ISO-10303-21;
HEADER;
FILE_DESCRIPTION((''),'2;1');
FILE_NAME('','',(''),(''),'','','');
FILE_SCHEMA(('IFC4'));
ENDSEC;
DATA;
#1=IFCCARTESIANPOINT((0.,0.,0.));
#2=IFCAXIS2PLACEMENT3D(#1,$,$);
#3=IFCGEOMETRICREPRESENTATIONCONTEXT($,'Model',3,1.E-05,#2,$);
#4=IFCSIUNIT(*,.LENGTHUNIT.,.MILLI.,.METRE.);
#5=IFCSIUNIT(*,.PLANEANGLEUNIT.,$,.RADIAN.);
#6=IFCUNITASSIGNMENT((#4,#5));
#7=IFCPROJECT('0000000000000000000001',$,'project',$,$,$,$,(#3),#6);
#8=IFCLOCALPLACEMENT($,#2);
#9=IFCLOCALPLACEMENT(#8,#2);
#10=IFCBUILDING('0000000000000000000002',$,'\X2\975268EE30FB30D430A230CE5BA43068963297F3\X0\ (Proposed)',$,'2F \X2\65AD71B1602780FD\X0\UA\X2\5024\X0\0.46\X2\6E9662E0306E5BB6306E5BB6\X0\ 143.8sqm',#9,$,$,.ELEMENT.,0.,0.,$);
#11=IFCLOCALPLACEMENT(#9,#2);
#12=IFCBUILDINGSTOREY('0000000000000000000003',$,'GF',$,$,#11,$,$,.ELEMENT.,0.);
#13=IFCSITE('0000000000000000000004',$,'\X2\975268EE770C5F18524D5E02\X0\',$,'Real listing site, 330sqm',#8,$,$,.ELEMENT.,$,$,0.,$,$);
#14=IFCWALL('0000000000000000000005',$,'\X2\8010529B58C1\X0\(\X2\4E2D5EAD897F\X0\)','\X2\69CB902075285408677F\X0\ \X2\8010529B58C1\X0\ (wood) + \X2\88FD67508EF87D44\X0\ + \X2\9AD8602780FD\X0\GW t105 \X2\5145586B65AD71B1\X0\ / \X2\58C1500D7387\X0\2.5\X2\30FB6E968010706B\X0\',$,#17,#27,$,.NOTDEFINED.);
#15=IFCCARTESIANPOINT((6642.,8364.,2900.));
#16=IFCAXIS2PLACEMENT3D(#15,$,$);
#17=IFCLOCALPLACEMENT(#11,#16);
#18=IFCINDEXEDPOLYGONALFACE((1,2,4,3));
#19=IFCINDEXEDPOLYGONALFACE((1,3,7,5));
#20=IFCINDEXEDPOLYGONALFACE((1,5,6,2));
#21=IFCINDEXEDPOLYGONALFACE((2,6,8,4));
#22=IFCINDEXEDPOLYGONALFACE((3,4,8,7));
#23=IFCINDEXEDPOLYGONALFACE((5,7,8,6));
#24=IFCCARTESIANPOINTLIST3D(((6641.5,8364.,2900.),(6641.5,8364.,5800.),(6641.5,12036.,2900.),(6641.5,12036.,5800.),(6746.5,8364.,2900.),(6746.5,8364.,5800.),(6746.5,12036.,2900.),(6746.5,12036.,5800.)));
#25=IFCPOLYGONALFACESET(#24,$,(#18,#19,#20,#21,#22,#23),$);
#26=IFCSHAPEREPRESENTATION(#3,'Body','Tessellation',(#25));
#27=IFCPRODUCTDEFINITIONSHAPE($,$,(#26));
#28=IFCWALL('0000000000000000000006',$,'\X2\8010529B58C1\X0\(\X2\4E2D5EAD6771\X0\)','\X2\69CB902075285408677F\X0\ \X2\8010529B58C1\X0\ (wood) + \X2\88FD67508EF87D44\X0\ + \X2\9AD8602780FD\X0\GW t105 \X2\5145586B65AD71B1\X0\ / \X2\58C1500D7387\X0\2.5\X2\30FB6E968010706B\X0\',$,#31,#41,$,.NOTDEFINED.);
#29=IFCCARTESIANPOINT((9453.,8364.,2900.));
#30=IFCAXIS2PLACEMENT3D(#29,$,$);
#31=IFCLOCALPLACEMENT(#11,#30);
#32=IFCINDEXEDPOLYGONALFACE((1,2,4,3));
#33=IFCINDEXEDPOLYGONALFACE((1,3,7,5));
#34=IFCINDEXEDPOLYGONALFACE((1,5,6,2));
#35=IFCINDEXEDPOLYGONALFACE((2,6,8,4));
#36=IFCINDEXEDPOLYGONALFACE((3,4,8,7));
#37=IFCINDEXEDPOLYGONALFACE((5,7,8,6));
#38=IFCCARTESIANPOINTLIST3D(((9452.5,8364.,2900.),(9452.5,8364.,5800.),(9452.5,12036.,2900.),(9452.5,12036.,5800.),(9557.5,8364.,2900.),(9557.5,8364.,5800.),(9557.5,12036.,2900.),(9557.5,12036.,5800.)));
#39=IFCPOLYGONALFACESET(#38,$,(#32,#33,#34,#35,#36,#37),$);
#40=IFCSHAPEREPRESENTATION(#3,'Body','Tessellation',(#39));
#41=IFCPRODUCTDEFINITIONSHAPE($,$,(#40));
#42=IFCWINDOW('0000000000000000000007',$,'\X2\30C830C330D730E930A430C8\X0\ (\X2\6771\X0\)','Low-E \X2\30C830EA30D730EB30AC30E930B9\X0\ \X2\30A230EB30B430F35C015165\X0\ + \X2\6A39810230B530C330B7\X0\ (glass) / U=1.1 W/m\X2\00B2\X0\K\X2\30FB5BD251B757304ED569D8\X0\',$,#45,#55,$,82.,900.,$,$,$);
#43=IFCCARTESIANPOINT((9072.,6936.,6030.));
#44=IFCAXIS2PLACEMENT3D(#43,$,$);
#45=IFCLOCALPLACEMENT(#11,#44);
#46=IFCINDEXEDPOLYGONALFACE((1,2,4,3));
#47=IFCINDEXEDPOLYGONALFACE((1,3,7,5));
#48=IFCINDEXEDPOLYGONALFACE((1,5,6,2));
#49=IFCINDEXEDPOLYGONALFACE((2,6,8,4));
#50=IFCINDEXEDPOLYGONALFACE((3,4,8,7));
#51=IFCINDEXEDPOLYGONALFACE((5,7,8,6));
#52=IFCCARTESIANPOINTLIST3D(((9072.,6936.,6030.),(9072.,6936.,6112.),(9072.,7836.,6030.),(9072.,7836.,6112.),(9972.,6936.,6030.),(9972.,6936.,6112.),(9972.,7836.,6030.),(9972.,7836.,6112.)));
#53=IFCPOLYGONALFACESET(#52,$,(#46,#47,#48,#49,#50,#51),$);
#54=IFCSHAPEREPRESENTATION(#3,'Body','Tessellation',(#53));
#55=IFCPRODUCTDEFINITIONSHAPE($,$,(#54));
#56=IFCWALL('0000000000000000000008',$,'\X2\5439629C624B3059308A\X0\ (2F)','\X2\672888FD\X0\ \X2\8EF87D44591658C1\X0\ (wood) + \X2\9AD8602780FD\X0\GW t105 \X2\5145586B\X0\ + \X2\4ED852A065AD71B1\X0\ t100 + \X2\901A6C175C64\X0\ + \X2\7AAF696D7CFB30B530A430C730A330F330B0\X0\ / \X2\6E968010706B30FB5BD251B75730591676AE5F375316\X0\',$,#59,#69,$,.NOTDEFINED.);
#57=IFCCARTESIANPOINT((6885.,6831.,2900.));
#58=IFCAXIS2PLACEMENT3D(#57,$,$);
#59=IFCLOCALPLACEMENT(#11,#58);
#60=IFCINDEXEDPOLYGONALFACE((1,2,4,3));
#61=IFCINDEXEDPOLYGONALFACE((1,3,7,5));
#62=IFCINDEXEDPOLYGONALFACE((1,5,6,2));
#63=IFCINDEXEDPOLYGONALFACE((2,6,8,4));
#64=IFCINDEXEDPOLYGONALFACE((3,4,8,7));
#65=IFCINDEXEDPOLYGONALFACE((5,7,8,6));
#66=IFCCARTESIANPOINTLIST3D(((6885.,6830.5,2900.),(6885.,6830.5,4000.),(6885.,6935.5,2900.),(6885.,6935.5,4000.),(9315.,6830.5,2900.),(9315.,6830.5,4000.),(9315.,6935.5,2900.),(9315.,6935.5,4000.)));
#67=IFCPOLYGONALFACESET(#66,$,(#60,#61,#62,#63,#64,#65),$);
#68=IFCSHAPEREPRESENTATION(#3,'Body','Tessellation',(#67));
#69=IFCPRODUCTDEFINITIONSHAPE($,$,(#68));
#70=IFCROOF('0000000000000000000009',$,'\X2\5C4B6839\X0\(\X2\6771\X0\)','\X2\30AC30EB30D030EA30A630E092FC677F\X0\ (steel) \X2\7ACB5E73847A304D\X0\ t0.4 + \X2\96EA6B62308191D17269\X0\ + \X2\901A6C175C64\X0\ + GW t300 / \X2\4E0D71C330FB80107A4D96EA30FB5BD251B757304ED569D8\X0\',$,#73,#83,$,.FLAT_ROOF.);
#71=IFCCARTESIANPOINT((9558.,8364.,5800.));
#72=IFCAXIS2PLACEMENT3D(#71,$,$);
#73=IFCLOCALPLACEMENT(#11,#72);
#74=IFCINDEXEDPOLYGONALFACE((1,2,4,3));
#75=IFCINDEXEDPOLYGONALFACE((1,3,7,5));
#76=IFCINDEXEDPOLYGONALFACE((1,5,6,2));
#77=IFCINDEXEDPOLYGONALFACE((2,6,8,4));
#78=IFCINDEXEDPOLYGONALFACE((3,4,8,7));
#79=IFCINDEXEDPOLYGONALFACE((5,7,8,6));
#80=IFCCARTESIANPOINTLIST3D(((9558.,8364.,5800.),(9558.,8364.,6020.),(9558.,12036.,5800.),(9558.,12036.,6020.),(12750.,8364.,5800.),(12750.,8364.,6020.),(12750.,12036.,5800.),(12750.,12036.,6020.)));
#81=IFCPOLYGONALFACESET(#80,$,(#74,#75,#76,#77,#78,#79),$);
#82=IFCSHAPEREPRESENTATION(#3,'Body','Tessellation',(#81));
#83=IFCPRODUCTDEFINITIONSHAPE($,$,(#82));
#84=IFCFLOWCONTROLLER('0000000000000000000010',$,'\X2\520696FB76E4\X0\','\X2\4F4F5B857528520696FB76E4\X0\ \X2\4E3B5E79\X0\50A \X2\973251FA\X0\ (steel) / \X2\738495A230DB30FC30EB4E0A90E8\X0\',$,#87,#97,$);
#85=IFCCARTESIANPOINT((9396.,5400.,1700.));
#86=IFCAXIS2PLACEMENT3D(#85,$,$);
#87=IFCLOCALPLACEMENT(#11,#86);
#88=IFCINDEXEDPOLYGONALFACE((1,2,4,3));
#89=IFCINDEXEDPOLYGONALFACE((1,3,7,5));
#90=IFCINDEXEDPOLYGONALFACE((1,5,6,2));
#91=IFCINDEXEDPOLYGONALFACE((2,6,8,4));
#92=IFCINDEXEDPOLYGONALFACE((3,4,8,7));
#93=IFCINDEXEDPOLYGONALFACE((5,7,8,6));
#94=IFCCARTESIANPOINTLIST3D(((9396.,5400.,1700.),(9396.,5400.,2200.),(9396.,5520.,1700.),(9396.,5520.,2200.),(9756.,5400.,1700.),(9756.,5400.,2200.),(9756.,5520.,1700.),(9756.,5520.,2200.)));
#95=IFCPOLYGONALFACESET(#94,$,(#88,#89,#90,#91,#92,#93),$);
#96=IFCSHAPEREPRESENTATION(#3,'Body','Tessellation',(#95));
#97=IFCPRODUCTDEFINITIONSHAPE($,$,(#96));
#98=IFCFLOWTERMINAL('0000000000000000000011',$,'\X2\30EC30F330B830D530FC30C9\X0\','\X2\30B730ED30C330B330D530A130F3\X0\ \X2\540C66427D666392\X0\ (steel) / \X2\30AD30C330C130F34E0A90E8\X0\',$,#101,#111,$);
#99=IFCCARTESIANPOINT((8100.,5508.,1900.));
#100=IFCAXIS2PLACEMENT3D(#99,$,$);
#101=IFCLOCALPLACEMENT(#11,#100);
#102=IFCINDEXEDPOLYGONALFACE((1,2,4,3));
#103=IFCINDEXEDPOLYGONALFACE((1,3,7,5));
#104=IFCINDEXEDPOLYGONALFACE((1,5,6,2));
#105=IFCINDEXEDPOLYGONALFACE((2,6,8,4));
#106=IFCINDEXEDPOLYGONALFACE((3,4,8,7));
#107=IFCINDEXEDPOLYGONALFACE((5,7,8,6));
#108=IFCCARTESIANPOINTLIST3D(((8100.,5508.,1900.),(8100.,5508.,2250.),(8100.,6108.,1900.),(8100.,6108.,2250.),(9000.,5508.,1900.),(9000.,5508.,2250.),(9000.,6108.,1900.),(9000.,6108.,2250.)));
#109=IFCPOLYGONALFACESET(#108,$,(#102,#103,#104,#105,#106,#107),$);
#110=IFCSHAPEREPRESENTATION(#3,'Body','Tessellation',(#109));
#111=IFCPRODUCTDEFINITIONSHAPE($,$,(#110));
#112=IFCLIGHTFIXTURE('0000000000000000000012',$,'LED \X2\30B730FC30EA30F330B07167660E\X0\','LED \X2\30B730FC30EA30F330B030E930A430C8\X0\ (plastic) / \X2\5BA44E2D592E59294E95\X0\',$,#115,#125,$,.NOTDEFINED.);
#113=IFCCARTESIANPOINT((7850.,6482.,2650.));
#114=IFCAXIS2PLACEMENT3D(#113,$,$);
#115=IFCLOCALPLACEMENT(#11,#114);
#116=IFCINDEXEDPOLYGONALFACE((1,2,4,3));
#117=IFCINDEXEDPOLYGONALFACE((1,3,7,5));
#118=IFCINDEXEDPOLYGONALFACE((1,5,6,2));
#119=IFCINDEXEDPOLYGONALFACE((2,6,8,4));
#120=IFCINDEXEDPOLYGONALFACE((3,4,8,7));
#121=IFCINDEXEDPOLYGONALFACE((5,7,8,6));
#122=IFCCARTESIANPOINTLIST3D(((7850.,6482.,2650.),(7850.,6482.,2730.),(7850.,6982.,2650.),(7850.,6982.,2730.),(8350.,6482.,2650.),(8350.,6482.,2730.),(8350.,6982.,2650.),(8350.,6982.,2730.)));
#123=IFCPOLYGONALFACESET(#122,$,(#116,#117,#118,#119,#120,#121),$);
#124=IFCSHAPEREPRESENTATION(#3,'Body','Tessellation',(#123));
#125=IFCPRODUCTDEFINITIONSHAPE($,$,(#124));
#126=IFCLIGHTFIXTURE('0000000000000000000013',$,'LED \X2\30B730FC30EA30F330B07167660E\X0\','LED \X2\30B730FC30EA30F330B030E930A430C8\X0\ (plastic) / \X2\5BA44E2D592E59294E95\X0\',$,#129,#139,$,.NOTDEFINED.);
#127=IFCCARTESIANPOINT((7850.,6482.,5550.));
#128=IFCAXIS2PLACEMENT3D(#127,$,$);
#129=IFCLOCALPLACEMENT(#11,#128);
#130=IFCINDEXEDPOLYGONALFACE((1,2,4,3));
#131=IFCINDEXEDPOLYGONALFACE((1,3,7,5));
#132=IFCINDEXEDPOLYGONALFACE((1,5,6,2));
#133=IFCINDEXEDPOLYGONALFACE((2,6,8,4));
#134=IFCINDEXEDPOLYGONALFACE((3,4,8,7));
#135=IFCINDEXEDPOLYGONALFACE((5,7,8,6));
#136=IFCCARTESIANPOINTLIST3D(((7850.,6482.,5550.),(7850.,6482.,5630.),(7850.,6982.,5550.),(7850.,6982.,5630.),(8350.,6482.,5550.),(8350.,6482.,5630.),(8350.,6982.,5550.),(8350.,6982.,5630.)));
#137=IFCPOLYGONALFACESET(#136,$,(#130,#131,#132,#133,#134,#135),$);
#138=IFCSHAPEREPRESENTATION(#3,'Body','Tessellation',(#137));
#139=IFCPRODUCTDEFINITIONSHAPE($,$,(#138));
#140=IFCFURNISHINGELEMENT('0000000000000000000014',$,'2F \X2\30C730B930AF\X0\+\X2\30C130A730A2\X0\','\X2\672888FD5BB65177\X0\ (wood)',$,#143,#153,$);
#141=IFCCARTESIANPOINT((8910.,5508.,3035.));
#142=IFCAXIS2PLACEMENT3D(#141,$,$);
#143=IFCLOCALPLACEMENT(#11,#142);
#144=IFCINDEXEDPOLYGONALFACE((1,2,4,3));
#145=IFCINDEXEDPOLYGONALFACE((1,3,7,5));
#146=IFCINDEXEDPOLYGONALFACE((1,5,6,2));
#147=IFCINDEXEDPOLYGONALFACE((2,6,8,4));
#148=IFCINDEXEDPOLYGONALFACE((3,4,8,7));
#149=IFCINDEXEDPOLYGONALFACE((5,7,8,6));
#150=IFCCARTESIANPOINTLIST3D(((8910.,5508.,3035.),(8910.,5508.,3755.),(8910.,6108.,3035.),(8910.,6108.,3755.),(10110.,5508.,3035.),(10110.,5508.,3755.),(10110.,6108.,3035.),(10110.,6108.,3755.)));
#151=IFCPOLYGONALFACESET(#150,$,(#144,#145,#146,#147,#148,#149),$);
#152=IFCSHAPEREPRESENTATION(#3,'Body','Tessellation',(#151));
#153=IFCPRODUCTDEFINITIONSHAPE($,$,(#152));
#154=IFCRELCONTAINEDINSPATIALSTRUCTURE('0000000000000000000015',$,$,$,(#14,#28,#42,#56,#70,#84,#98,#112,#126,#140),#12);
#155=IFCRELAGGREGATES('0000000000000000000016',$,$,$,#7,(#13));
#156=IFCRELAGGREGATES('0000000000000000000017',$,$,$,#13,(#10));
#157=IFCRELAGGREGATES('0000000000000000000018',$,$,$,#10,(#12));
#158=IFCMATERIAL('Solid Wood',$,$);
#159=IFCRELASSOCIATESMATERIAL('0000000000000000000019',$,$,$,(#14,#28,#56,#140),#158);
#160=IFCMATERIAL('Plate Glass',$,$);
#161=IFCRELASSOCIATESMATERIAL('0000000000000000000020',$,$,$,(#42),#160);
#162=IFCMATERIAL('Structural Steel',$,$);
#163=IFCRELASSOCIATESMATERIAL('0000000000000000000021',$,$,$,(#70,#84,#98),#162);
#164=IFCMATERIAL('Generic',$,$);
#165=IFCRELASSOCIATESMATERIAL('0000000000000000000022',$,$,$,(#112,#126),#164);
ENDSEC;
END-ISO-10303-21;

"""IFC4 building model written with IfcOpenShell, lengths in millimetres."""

from ifc_helpers import new_model, si_unit, frame, frame_2d, origin, place, context, project, spatial, rectangle, extrude, material, element, save


model = new_model("IFC4")

# Units and contexts
model_context = context("Model", 3, precision=1e-05, world=origin())
ifc_project = project(units=[si_unit("LENGTHUNIT", "METRE", prefix="MILLI"), si_unit("PLANEANGLEUNIT", "RADIAN")], contexts=[model_context])

# Site, building, storey
site_placement = place(None, origin())
site = spatial("IfcSite", under=ifc_project, at=site_placement, Name="青森県弘前市", ObjectType="Real listing site, 330sqm", CompositionType="ELEMENT", RefElevation=0.0)
building_placement = place(site_placement, origin())
building = spatial("IfcBuilding", under=site, at=building_placement, Name="青森・ピアノ室と防音 (Proposed)", ObjectType="2F 断熱性能UA値0.46準拠の家の家 143.8sqm", CompositionType="ELEMENT", ElevationOfRefHeight=0.0, ElevationOfTerrain=0.0)
storey_placement = place(building_placement, origin())
storey = spatial("IfcBuildingStorey", under=building, at=storey_placement, Name="GF", CompositionType="ELEMENT", Elevation=0.0)

# Shared definitions
ifc_material_1 = material(Name="Solid Wood")

# Shared definitions
ifc_material_2 = material(Name="Plate Glass")

# Walls
wall_1_placement = place(storey_placement, frame((6642.0, 8364.0, 2900.0)))
element("IfcWall", 1, at=wall_1_placement, inside=storey, material=ifc_material_1, Name="耐力壁(中庭西)", Description="構造用合板 耐力壁 (wood) + 製材軸組 + 高性能GW t105 充填断熱 / 壁倍率2.5・準耐火", PredefinedType="NOTDEFINED", context=model_context, shape_type="SweptSolid", body=[
    extrude(rectangle(XDim=105.0, YDim=3672.0, at=frame_2d((52.0, 1836.0))), frame((6642.0, 8364.0, 2900.0)), (0.0, 0.0, 1.0), 2900.0),
])
wall_2_placement = place(storey_placement, frame((9453.0, 8364.0, 2900.0)))
element("IfcWall", 2, at=wall_2_placement, inside=storey, material=ifc_material_1, Name="耐力壁(中庭東)", Description="構造用合板 耐力壁 (wood) + 製材軸組 + 高性能GW t105 充填断熱 / 壁倍率2.5・準耐火", PredefinedType="NOTDEFINED", context=model_context, shape_type="SweptSolid", body=[
    extrude(rectangle(XDim=105.0, YDim=3672.0, at=frame_2d((52.0, 1836.0))), frame((9453.0, 8364.0, 2900.0)), (0.0, 0.0, 1.0), 2900.0),
])

# Window
window_1_placement = place(storey_placement, frame((9072.0, 6936.0, 6030.0)))
element("IfcWindow", 3, at=window_1_placement, inside=storey, material=ifc_material_2, Name="トップライト (東)", Description="Low-E トリプルガラス アルゴン封入 + 樹脂サッシ (glass) / U=1.1 W/m²K・寒冷地仕様", OverallHeight=82.0, OverallWidth=900.0, context=model_context, shape_type="SweptSolid", body=[
    extrude(rectangle(XDim=900.0, YDim=900.0, at=frame_2d((450.0, 450.0))), frame((9072.0, 6936.0, 6030.0)), (0.0, 0.0, 1.0), 82.0),
])

# Wall
wall_3_placement = place(storey_placement, frame((6885.0, 6831.0, 2900.0)))
element("IfcWall", 4, at=wall_3_placement, inside=storey, material=ifc_material_1, Name="吹抜手すり (2F)", Description="木製 軸組外壁 (wood) + 高性能GW t105 充填 + 付加断熱 t100 + 通気層 + 窯業系サイディング / 準耐火・寒冷地外皮強化", PredefinedType="NOTDEFINED", context=model_context, shape_type="SweptSolid", body=[
    extrude(rectangle(XDim=2430.0, YDim=105.0, at=frame_2d((1215.0, 52.0))), frame((6885.0, 6831.0, 2900.0)), (0.0, 0.0, 1.0), 1100.0),
])

# Roof
ifc_material_3 = material(Name="Structural Steel")
for number, where, name in (
    (5, (9558.0, 8364.0, 5800.0), "屋根(東)"),
):
    element("IfcRoof", number, at=place(storey_placement, frame(where)), inside=storey, material=ifc_material_3, Name=name, Description="ガルバリウム鋼板 (steel) 立平葺き t0.4 + 雪止め金物 + 通気層 + GW t300 / 不燃・耐積雪・寒冷地仕様", PredefinedType="FLAT_ROOF", context=model_context, shape_type="SweptSolid", body=[
        extrude(rectangle(XDim=3192.0, YDim=3672.0, at=frame_2d((1596.0, 1836.0))), frame((9558.0, 8364.0, 5800.0)), (0.0, 0.0, 1.0), 220.0),
    ])

# Flow controller
flow_controller_placement = place(storey_placement, frame((9396.0, 5400.0, 1700.0)))
element("IfcFlowController", 6, at=flow_controller_placement, inside=storey, material=ifc_material_3, Name="分電盤", Description="住宅用分電盤 主幹50A 露出 (steel) / 玄関ホール上部", context=model_context, shape_type="SweptSolid", body=[
    extrude(rectangle(XDim=360.0, YDim=120.0, at=frame_2d((180.0, 60.0))), frame((9396.0, 5400.0, 1700.0)), (0.0, 0.0, 1.0), 500.0),
])

# Flow terminal
flow_terminal_placement = place(storey_placement, frame((8100.0, 5508.0, 1900.0)))
element("IfcFlowTerminal", 7, at=flow_terminal_placement, inside=storey, material=ifc_material_3, Name="レンジフード", Description="シロッコファン 同時給排 (steel) / キッチン上部", context=model_context, shape_type="SweptSolid", body=[
    extrude(rectangle(XDim=900.0, YDim=600.0, at=frame_2d((450.0, 300.0))), frame((8100.0, 5508.0, 1900.0)), (0.0, 0.0, 1.0), 350.0),
])

# Light fixtures
ifc_material_4 = material(Name="Generic")
light_fixture_1_placement = place(storey_placement, frame((7850.0, 6482.0, 2650.0)))
element("IfcLightFixture", 8, at=light_fixture_1_placement, inside=storey, material=ifc_material_4, Name="LED シーリング照明", Description="LED シーリングライト (plastic) / 室中央天井", PredefinedType="NOTDEFINED", context=model_context, shape_type="SweptSolid", body=[
    extrude(rectangle(XDim=500.0, YDim=500.0, at=frame_2d((250.0, 250.0))), frame((7850.0, 6482.0, 2650.0)), (0.0, 0.0, 1.0), 80.0),
])
light_fixture_2_placement = place(storey_placement, frame((7850.0, 6482.0, 5550.0)))
element("IfcLightFixture", 9, at=light_fixture_2_placement, inside=storey, material=ifc_material_4, Name="LED シーリング照明", Description="LED シーリングライト (plastic) / 室中央天井", PredefinedType="NOTDEFINED", context=model_context, shape_type="SweptSolid", body=[
    extrude(rectangle(XDim=500.0, YDim=500.0, at=frame_2d((250.0, 250.0))), frame((7850.0, 6482.0, 5550.0)), (0.0, 0.0, 1.0), 80.0),
])

# Furnishing element
furnishing_placement = place(storey_placement, frame((8910.0, 5508.0, 3035.0)))
element("IfcFurnishingElement", 10, at=furnishing_placement, inside=storey, material=ifc_material_1, Name="2F デスク+チェア", Description="木製家具 (wood)", context=model_context, shape_type="SweptSolid", body=[
    extrude(rectangle(XDim=1200.0, YDim=600.0, at=frame_2d((600.0, 300.0))), frame((8910.0, 5508.0, 3035.0)), (0.0, 0.0, 1.0), 720.0),
])

save(model, "model.ifc")
